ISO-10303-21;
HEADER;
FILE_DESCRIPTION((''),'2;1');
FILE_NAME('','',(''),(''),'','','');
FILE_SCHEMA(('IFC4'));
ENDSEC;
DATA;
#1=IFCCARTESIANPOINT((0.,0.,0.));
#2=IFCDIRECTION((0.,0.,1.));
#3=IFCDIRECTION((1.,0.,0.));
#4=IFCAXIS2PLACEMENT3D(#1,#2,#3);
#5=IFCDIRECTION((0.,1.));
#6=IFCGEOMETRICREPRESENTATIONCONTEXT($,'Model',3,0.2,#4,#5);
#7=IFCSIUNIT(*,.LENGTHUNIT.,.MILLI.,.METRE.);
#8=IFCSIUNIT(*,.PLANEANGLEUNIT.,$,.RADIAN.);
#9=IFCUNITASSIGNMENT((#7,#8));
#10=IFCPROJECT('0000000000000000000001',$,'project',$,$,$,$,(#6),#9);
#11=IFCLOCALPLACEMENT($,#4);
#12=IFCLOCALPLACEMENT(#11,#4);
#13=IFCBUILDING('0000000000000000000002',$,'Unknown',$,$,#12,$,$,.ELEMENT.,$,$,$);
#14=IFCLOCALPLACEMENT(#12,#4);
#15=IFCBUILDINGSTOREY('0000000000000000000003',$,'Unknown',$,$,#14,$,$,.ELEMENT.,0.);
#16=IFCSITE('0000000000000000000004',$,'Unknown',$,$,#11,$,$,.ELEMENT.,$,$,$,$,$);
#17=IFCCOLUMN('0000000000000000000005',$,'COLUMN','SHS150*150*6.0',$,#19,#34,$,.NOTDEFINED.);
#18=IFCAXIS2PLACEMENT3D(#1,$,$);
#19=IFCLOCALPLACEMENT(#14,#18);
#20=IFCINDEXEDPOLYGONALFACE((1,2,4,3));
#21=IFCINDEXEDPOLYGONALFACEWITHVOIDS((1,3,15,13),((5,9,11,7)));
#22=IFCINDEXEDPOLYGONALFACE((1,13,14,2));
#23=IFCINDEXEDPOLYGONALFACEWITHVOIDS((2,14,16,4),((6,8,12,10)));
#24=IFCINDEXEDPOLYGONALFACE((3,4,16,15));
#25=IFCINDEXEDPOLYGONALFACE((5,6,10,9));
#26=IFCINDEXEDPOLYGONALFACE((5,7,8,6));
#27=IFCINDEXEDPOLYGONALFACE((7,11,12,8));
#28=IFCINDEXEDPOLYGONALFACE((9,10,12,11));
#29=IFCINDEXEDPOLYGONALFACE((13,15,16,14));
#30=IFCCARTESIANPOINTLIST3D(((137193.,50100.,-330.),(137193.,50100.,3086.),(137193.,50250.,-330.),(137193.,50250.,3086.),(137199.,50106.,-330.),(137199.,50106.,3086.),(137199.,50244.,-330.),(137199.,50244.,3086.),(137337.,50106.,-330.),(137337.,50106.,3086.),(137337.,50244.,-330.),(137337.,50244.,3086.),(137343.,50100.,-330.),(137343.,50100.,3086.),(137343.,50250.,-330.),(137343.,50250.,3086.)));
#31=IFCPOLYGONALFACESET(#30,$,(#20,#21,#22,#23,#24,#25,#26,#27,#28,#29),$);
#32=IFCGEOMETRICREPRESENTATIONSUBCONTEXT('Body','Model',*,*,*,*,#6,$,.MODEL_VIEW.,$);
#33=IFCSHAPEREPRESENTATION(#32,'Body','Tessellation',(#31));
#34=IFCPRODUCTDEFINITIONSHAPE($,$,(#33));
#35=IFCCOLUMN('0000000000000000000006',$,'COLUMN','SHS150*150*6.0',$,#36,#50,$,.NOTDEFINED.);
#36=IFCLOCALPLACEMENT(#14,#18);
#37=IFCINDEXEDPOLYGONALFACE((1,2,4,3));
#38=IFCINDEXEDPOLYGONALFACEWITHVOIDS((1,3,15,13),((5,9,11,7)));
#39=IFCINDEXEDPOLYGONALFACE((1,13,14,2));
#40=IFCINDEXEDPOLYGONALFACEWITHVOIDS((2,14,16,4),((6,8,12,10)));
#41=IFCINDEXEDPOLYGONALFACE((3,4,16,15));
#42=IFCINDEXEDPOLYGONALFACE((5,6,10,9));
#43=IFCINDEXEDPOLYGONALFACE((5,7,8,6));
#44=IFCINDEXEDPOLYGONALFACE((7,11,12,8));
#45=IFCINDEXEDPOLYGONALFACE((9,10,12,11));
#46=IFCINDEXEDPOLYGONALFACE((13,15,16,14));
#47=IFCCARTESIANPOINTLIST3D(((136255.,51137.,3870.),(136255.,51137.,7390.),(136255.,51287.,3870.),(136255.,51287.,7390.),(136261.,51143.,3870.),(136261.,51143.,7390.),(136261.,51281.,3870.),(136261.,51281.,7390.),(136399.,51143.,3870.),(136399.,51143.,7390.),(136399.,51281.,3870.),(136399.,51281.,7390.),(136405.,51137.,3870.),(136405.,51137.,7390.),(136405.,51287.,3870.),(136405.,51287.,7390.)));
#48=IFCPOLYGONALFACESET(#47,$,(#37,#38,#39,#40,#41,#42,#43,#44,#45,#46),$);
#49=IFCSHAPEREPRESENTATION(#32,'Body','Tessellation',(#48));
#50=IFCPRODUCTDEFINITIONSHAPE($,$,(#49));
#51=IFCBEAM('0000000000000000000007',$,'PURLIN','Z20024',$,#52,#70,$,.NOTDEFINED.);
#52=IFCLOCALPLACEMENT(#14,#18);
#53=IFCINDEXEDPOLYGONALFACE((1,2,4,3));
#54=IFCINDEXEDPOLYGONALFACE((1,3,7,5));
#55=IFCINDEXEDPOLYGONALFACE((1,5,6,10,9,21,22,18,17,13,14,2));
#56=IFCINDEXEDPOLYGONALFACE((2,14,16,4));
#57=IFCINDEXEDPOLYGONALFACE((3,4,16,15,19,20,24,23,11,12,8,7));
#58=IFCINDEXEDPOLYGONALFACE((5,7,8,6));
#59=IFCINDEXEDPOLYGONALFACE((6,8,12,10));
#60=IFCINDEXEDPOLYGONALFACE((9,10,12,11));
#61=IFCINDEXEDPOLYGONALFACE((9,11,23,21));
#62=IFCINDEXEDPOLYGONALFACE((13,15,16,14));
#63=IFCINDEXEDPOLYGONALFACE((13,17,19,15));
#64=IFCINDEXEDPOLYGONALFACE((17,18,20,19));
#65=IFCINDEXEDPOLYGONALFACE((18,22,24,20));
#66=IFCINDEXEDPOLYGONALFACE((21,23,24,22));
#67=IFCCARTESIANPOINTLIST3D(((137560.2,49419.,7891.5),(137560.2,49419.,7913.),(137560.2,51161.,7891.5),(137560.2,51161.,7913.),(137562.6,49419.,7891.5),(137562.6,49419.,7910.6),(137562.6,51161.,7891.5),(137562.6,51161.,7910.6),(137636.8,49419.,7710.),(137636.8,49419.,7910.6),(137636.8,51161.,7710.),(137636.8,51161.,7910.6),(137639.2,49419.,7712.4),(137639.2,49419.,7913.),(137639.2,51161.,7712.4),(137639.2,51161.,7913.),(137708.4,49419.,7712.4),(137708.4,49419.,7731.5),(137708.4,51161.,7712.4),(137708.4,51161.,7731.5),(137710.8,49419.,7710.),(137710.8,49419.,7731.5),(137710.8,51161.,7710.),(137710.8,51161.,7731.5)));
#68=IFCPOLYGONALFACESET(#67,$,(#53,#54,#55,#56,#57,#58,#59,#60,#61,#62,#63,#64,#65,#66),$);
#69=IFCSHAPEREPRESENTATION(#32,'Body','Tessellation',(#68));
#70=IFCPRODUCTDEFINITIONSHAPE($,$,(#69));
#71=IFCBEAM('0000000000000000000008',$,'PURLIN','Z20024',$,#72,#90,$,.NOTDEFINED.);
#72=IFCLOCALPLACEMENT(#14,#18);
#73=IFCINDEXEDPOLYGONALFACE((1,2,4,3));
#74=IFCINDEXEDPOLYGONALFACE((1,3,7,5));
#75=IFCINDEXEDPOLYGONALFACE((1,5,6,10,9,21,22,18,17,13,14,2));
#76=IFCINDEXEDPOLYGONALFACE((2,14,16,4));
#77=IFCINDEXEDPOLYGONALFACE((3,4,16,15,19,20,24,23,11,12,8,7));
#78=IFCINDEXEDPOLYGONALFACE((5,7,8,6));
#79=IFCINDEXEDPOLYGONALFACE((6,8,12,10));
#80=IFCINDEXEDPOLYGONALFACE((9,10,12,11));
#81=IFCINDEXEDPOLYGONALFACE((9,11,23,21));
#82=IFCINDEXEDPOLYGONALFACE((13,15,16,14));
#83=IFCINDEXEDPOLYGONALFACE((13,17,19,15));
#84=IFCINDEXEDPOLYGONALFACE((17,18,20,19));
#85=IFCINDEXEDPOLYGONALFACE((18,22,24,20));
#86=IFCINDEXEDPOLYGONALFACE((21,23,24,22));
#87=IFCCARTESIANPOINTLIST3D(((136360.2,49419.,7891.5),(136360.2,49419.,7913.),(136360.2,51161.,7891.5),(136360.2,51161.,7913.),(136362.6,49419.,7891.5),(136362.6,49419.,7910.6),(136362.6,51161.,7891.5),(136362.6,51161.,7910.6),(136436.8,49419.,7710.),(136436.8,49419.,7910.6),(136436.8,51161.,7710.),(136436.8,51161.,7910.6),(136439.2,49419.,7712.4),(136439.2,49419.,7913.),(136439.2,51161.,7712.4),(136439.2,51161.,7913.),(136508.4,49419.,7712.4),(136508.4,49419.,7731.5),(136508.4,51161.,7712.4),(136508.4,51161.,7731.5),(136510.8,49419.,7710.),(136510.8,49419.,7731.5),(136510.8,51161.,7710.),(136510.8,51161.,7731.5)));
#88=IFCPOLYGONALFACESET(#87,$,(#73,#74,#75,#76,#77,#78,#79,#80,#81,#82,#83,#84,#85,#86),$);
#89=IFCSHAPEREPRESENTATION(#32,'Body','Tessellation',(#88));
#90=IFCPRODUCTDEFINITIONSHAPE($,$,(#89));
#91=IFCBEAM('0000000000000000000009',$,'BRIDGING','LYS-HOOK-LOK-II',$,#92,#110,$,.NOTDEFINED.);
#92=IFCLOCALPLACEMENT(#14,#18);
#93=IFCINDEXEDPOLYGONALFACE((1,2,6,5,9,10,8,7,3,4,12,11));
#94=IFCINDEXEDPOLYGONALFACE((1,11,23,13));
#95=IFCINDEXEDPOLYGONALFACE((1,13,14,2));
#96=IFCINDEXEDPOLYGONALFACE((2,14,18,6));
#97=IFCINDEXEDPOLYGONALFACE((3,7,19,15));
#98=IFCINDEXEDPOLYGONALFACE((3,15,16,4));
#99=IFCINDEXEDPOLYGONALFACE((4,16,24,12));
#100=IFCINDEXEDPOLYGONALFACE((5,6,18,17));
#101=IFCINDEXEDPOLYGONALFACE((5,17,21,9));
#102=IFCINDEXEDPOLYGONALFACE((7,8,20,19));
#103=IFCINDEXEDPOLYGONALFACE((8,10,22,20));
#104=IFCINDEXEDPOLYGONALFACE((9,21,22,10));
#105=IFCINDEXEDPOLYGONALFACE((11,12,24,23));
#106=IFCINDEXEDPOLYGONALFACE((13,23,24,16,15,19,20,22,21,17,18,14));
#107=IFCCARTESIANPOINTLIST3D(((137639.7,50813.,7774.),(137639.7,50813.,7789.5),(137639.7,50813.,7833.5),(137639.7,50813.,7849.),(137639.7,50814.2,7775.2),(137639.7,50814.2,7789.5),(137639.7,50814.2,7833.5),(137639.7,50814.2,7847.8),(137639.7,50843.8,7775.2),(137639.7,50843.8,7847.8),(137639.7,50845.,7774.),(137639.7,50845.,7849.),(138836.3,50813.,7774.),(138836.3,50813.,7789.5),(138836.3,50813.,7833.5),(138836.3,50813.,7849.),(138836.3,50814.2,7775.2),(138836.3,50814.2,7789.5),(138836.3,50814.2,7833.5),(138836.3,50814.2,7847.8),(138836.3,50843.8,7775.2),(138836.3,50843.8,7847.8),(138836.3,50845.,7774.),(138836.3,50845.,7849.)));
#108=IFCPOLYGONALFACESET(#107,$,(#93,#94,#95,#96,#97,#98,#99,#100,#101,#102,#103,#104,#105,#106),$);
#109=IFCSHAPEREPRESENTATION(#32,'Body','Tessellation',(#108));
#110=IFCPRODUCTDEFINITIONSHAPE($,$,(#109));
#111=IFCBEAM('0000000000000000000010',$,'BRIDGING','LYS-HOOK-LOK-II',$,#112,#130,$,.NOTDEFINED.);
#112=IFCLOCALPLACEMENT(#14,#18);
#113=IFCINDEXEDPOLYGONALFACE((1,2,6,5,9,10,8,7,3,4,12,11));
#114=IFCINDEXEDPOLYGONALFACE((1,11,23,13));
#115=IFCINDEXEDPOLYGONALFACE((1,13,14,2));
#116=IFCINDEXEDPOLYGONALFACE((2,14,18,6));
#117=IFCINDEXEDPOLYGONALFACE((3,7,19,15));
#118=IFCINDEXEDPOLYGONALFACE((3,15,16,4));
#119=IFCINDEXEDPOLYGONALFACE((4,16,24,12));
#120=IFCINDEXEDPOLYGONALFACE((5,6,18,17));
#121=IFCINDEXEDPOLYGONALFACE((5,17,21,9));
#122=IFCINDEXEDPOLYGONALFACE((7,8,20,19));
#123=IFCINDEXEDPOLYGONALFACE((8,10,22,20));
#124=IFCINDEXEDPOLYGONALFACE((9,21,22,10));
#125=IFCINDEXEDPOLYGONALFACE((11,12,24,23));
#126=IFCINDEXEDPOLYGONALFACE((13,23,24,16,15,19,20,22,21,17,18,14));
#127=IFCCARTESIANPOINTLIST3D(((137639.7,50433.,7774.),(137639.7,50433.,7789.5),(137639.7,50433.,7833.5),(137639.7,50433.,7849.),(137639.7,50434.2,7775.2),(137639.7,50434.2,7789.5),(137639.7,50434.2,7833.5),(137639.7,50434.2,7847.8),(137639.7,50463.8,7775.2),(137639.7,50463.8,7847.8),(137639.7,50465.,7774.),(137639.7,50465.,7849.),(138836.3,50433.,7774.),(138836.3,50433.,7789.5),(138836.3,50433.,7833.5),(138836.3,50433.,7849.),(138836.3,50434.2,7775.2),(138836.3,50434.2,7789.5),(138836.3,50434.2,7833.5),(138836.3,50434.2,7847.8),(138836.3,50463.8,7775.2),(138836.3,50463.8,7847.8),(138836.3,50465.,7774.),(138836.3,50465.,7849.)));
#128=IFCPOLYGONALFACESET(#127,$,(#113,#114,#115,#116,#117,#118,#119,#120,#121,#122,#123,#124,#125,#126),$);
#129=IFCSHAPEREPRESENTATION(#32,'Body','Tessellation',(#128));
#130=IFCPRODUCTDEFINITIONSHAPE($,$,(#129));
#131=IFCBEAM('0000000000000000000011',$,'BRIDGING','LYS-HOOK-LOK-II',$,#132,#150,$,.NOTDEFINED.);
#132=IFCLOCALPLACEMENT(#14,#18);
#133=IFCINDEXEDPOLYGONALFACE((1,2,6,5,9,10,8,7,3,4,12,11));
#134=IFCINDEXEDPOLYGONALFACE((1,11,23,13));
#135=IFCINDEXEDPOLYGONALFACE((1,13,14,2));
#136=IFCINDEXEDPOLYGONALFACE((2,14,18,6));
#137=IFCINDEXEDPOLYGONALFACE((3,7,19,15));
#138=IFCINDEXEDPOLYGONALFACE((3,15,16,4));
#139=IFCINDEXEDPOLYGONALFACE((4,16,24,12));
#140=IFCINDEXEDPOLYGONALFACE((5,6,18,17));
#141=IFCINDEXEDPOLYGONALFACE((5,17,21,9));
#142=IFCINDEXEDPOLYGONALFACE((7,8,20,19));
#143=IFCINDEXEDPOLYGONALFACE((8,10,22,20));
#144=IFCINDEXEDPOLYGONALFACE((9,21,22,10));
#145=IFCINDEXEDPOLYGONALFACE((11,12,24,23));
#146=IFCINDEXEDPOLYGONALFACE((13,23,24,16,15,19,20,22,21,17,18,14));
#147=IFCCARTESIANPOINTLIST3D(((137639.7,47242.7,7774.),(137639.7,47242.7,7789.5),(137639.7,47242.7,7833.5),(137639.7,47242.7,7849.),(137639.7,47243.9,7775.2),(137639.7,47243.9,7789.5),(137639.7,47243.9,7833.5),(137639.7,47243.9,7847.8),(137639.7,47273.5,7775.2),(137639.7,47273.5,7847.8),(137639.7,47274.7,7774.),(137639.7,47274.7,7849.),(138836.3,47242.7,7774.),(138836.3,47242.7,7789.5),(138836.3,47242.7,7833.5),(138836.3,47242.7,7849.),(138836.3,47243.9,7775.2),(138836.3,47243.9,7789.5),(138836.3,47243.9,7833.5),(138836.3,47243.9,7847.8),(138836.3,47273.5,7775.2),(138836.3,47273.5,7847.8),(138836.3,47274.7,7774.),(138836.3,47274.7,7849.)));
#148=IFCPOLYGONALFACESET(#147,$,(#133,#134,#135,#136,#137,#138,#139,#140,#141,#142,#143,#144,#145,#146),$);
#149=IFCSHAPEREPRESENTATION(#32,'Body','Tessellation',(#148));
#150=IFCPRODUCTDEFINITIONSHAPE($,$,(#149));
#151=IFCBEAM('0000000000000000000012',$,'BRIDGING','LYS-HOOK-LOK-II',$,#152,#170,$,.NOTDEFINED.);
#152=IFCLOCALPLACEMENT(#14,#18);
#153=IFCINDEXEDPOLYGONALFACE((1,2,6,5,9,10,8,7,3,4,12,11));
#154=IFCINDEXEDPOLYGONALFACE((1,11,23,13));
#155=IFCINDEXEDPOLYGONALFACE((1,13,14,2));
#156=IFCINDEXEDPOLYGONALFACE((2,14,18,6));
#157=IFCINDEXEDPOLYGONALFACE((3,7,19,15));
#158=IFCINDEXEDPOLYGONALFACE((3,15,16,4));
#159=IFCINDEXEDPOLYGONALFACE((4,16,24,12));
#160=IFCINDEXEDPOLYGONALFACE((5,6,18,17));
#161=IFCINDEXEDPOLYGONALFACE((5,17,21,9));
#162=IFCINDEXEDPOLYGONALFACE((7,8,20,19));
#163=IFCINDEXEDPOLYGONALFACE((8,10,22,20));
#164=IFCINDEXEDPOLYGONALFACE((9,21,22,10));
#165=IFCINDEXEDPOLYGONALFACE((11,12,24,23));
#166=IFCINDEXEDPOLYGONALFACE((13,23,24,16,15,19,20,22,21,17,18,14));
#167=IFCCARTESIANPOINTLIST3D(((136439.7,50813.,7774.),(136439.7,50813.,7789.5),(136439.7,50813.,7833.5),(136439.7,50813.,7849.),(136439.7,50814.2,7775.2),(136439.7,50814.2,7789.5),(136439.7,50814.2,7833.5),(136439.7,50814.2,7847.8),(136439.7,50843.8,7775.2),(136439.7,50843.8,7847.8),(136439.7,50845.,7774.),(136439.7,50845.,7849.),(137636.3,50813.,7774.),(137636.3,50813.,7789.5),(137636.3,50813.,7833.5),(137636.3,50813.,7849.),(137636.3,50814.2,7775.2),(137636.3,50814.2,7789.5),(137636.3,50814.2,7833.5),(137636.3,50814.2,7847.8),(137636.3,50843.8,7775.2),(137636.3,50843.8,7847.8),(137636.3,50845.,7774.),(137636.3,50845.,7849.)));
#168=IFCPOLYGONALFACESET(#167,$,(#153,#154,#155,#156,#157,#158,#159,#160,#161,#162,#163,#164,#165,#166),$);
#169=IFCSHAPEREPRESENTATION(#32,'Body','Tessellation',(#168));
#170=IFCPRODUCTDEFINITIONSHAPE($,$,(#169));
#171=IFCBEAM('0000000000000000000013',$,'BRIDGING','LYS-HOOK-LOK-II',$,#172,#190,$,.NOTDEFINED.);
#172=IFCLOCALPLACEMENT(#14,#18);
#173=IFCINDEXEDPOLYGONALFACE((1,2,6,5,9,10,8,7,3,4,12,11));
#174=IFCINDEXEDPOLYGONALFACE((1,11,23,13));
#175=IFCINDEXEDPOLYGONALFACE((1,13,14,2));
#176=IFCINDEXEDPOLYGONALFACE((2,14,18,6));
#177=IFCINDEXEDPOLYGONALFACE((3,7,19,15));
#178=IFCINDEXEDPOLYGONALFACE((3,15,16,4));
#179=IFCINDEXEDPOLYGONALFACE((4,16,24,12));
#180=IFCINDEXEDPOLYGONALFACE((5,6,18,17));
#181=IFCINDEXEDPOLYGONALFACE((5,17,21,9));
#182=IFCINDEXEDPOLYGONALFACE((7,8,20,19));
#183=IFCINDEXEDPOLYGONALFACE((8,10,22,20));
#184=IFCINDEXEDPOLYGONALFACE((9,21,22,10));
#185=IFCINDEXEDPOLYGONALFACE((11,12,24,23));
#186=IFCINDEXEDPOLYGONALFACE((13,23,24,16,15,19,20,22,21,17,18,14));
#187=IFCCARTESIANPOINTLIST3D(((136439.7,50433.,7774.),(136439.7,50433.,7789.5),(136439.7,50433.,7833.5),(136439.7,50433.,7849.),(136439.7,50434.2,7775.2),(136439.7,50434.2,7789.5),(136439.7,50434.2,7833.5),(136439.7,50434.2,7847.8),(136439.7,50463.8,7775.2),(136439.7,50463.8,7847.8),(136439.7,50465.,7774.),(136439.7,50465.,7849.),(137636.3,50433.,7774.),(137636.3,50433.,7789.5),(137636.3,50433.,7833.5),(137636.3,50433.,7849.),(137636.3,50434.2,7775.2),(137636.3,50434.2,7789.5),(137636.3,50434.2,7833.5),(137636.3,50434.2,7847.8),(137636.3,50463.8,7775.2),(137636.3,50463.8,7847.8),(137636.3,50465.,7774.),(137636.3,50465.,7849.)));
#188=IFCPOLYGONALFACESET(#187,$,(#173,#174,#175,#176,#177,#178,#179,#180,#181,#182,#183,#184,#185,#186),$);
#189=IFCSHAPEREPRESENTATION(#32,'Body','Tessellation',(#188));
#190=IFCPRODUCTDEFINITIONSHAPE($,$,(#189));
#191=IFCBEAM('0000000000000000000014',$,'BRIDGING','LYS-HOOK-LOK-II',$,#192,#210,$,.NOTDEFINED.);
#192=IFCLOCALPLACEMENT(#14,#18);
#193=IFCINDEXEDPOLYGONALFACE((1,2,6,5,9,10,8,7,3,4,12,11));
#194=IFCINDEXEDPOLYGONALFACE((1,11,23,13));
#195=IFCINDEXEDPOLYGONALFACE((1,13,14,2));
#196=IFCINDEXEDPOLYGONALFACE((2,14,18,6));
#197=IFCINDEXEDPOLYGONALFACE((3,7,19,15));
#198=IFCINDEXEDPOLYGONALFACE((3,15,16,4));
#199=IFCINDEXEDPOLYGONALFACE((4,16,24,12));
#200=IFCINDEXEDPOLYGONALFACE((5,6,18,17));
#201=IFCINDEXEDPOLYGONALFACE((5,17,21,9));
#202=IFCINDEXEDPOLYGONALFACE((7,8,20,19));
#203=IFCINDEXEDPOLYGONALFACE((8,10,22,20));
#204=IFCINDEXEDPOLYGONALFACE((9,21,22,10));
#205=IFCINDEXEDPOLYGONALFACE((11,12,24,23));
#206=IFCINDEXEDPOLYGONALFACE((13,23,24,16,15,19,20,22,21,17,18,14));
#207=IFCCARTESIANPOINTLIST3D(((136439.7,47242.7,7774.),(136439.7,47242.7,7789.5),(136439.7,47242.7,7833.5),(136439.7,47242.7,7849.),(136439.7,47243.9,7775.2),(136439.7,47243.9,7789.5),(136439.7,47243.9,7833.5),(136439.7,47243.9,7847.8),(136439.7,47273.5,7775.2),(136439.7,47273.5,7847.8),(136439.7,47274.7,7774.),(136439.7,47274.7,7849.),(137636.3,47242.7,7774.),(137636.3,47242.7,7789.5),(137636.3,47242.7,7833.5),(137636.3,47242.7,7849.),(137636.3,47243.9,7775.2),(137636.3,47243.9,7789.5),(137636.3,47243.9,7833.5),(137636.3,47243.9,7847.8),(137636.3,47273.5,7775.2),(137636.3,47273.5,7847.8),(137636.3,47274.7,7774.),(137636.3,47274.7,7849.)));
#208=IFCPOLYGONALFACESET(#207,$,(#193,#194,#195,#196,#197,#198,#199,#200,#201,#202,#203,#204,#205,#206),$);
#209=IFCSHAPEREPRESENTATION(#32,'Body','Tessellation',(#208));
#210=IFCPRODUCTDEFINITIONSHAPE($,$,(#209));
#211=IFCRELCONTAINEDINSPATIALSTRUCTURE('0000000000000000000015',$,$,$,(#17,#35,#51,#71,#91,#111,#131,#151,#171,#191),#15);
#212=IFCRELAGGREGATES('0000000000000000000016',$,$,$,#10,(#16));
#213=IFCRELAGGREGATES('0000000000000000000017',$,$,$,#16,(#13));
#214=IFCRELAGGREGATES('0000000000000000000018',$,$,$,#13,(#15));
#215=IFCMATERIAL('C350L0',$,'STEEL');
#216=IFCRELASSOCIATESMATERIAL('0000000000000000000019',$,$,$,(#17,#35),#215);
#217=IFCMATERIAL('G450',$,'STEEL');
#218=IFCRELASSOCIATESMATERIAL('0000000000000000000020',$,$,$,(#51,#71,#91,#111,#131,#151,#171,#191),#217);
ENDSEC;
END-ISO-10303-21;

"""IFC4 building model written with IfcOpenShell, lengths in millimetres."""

from ifc_helpers import new_model, si_unit, direction, frame, origin_with_axes, place, context, subcontext, project, spatial, line, indexed_curve, outline, extrude, material, element, save


model = new_model("IFC4")

# Units and contexts
model_context = context("Model", 3, precision=0.2, world=origin_with_axes(), true_north=direction((0.0, 1.0)))
body_context = subcontext(model_context, "Body", "Model", "MODEL_VIEW")
ifc_project = project(units=[si_unit("LENGTHUNIT", "METRE", prefix="MILLI"), si_unit("PLANEANGLEUNIT", "RADIAN")], contexts=[model_context])

# Site, building, storey
site_placement = place(None, origin_with_axes())
site = spatial("IfcSite", under=ifc_project, at=site_placement, Name="Unknown", CompositionType="ELEMENT")
building_placement = place(site_placement, origin_with_axes())
building = spatial("IfcBuilding", under=site, at=building_placement, Name="Unknown", CompositionType="ELEMENT")
storey_placement = place(building_placement, origin_with_axes())
storey = spatial("IfcBuildingStorey", under=building, at=storey_placement, Name="Unknown", CompositionType="ELEMENT", Elevation=0.0)

# Columns
ifc_material_1 = material(Name="C350L0", Category="STEEL")
column_1_placement = place(storey_placement, frame((137268.0, 50175.0, -330.0), z_axis=(-1.0, 0.0, 0.0), x_axis=(0.0, 0.0, 1.0)))
element("IfcColumn", 1, at=column_1_placement, inside=storey, material=ifc_material_1, Name="COLUMN", Description="SHS150*150*6.0", PredefinedType="NOTDEFINED", context=body_context, shape_type="SolidModel", body=[
    extrude(outline(indexed_curve([(-75.0, -75.0), (75.0, -75.0), (75.0, 75.0), (-75.0, 75.0)], segments=[line(1, 2, 3, 4, 1)]), holes=[indexed_curve([(-69.0, -69.0), (-69.0, 69.0), (69.0, 69.0), (69.0, -69.0)], segments=[line(1, 2, 3, 4, 1)])]), frame((0.0, 0.0, 0.0), z_axis=(-1.0, 0.0, 0.0), x_axis=(0.0, 0.0, 1.0)), (0.0, 0.0, -1.0), 3416.0),
])
column_2_placement = place(storey_placement, frame((136330.0, 51212.0, 3870.0), z_axis=(-1.0, 0.0, 0.0), x_axis=(0.0, 0.0, 1.0)))
element("IfcColumn", 2, at=column_2_placement, inside=storey, material=ifc_material_1, Name="COLUMN", Description="SHS150*150*6.0", PredefinedType="NOTDEFINED", context=body_context, shape_type="SolidModel", body=[
    extrude(outline(indexed_curve([(-75.0, -75.0), (75.0, -75.0), (75.0, 75.0), (-75.0, 75.0)], segments=[line(1, 2, 3, 4, 1)]), holes=[indexed_curve([(-69.0, -69.0), (-69.0, 69.0), (69.0, 69.0), (69.0, -69.0)], segments=[line(1, 2, 3, 4, 1)])]), frame((0.0, 0.0, 0.0), z_axis=(-1.0, 0.0, 0.0), x_axis=(0.0, 0.0, 1.0)), (0.0, 0.0, -1.0), 3520.0),
])

# Beams
ifc_material_2 = material(Name="G450", Category="STEEL")
for number, where, z_axis, x_axis, name in (
    (3, (137638.0, 49419.0, 7811.5), (1.0, 0.0, 0.0), (0.0, 1.0, 0.0), "PURLIN"),
    (4, (136438.0, 49419.0, 7811.5), (1.0, 0.0, 0.0), (0.0, 1.0, 0.0), "PURLIN"),
):
    element("IfcBeam", number, at=place(storey_placement, frame(where, z_axis=z_axis, x_axis=x_axis)), inside=storey, material=ifc_material_2, Name=name, Description="Z20024", PredefinedType="NOTDEFINED", context=body_context, shape_type="SolidModel", body=[
        extrude(outline(indexed_curve([(72.8, -101.5), (72.8, -80.0), (70.4, -80.0), (70.4, -99.1), (1.2, -99.1), (1.2, 101.5), (-77.8, 101.5), (-77.8, 80.0), (-75.4, 80.0), (-75.4, 99.1), (-1.2, 99.1), (-1.2, -101.5)], segments=[line(1, 2, 3, 4, 5, 6, 7, 8, 9, 10, 11, 12, 1)])), frame((0.0, 0.0, 0.0), z_axis=(-1.0, 0.0, 0.0), x_axis=(0.0, 0.0, 1.0)), (0.0, 0.0, -1.0), 1742.0),
    ])
for number, where, z_axis, x_axis, name in (
    (5, (137639.7, 50829.0, 7811.5), (0.0, -1.0, 0.0), (1.0, 0.0, 0.0), "BRIDGING"),
    (6, (137639.7, 50449.0, 7811.5), (0.0, -1.0, 0.0), (1.0, 0.0, 0.0), "BRIDGING"),
    (7, (137639.7, 47258.7, 7811.5), (0.0, -1.0, 0.0), (1.0, 0.0, 0.0), "BRIDGING"),
    (8, (136439.7, 50829.0, 7811.5), (0.0, -1.0, 0.0), (1.0, 0.0, 0.0), "BRIDGING"),
    (9, (136439.7, 50449.0, 7811.5), (0.0, -1.0, 0.0), (1.0, 0.0, 0.0), "BRIDGING"),
    (10, (136439.7, 47258.7, 7811.5), (0.0, -1.0, 0.0), (1.0, 0.0, 0.0), "BRIDGING"),
):
    element("IfcBeam", number, at=place(storey_placement, frame(where, z_axis=z_axis, x_axis=x_axis)), inside=storey, material=ifc_material_2, Name=name, Description="LYS-HOOK-LOK-II", PredefinedType="NOTDEFINED", context=body_context, shape_type="SolidModel", body=[
        extrude(outline(indexed_curve([(16.0, -37.5), (16.0, -22.0), (14.8, -22.0), (14.8, -36.3), (-14.8, -36.3), (-14.8, 36.3), (14.8, 36.3), (14.8, 22.0), (16.0, 22.0), (16.0, 37.5), (-16.0, 37.5), (-16.0, -37.5)], segments=[line(1, 2, 3, 4, 5, 6, 7, 8, 9, 10, 11, 12, 1)])), frame((0.0, 0.0, 0.0), z_axis=(-1.0, 0.0, 0.0), x_axis=(0.0, 0.0, 1.0)), (0.0, 0.0, -1.0), 1196.6),
    ])

save(model, "model.ifc")
